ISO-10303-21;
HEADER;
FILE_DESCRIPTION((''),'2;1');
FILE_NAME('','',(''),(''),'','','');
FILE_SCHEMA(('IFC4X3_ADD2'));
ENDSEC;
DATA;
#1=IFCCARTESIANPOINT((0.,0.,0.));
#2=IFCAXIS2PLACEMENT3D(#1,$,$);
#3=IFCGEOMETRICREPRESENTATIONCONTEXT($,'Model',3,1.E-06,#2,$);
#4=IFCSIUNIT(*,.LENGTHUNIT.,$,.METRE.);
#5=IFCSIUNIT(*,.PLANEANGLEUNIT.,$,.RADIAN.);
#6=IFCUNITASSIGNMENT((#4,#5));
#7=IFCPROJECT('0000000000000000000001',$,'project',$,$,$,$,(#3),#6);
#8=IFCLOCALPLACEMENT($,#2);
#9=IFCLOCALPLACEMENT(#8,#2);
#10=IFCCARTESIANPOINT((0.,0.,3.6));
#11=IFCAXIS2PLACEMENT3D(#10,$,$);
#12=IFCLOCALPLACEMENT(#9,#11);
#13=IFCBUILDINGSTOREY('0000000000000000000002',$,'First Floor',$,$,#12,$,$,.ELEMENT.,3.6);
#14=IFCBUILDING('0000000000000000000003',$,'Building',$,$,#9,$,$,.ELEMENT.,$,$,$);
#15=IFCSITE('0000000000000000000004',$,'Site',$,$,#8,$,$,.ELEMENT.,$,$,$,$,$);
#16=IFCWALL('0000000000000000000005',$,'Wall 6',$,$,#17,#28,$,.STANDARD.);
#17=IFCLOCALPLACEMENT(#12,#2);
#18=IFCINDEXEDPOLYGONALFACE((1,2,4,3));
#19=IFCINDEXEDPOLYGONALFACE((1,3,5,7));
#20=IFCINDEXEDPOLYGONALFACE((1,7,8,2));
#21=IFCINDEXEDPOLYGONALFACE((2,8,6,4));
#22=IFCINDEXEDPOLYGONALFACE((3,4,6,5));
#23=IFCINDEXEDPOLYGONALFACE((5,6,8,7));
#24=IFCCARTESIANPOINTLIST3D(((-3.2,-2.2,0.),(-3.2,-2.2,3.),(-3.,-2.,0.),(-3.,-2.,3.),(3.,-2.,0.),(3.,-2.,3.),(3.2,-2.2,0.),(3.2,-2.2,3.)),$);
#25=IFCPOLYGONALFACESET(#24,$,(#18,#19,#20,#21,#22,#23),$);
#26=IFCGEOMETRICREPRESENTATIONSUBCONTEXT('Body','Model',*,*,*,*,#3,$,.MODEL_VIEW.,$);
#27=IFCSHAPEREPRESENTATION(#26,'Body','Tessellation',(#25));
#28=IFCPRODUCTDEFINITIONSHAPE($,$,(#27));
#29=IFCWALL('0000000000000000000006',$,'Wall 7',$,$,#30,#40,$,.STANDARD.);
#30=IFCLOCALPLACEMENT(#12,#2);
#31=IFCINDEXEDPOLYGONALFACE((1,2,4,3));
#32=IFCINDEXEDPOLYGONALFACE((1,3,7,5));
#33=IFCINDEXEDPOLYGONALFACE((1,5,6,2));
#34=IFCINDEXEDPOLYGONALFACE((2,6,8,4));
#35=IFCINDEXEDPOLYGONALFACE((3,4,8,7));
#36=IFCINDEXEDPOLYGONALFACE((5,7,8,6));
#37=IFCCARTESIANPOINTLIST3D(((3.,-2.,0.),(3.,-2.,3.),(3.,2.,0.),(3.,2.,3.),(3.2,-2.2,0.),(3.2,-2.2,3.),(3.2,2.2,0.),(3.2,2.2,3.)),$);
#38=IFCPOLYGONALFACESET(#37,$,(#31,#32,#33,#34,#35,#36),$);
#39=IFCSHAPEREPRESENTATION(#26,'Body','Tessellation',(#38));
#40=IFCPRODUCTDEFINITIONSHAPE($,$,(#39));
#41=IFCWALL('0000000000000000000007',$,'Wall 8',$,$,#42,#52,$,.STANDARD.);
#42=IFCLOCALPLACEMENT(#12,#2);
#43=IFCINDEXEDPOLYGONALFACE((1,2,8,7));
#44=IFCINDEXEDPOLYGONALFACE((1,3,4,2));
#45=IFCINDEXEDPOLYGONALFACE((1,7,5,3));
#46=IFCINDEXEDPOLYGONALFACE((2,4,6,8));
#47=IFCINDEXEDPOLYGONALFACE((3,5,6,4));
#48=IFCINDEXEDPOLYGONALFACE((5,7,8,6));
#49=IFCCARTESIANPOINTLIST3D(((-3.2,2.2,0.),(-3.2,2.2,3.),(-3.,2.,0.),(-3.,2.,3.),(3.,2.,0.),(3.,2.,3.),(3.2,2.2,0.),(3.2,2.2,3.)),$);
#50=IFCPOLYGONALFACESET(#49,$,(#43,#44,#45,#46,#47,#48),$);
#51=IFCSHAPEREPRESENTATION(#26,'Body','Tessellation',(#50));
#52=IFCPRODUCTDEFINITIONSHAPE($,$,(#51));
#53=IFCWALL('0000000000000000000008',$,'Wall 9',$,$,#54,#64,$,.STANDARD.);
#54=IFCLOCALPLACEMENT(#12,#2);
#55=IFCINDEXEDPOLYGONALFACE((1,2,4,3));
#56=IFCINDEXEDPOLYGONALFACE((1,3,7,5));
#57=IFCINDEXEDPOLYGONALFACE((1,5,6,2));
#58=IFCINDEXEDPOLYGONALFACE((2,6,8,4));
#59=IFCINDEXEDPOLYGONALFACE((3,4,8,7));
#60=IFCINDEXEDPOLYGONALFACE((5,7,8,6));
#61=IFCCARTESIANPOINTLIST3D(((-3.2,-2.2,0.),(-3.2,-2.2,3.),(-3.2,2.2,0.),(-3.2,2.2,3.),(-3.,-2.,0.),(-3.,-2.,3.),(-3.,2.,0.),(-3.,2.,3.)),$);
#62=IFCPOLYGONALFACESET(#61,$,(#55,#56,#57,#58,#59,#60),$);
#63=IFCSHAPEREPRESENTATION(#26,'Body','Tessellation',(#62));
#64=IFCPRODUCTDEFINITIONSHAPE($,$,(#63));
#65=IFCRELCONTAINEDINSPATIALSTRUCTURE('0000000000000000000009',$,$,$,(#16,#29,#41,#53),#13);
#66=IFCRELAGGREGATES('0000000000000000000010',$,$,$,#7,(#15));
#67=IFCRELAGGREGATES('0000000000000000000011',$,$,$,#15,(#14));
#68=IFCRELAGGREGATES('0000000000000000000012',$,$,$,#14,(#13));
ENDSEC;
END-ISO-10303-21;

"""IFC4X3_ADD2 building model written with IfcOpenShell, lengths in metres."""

from ifc_helpers import new_model, si_unit, frame, origin, place, context, subcontext, project, spatial, polyline, outline, extrude, element, save


model = new_model("IFC4X3_ADD2")

# Units and contexts
model_context = context("Model", 3, precision=1e-06, world=origin())
body_context = subcontext(model_context, "Body", "Model", "MODEL_VIEW")
ifc_project = project(units=[si_unit("LENGTHUNIT", "METRE"), si_unit("PLANEANGLEUNIT", "RADIAN")], contexts=[model_context])

# Site, building, storey
site_placement = place(None, origin())
site = spatial("IfcSite", under=ifc_project, at=site_placement, Name="Site", CompositionType="ELEMENT")
building_placement = place(site_placement, origin())
building = spatial("IfcBuilding", under=site, at=building_placement, Name="Building", CompositionType="ELEMENT")
storey_placement = place(building_placement, frame((0.0, 0.0, 3.6)))
storey = spatial("IfcBuildingStorey", under=building, at=storey_placement, Name="First Floor", CompositionType="ELEMENT", Elevation=3.6)

# Walls
wall_1_placement = place(storey_placement, origin())
element("IfcWall", 1, at=wall_1_placement, inside=storey, Name="Wall 6", PredefinedType="STANDARD", context=body_context, shape_type="SweptSolid", body=[
    extrude(outline(polyline([(-3.0, -2.0), (3.0, -2.0), (3.2, -2.2), (-3.2, -2.2), (-3.0, -2.0)])), origin(), (0.0, 0.0, 1.0), 3.0),
])
wall_2_placement = place(storey_placement, origin())
element("IfcWall", 2, at=wall_2_placement, inside=storey, Name="Wall 7", PredefinedType="STANDARD", context=body_context, shape_type="SweptSolid", body=[
    extrude(outline(polyline([(3.0, -2.0), (3.0, 2.0), (3.2, 2.2), (3.2, -2.2), (3.0, -2.0)])), origin(), (0.0, 0.0, 1.0), 3.0),
])
wall_3_placement = place(storey_placement, origin())
element("IfcWall", 3, at=wall_3_placement, inside=storey, Name="Wall 8", PredefinedType="STANDARD", context=body_context, shape_type="SweptSolid", body=[
    extrude(outline(polyline([(3.0, 2.0), (-3.0, 2.0), (-3.2, 2.2), (3.2, 2.2), (3.0, 2.0)])), origin(), (0.0, 0.0, 1.0), 3.0),
])
wall_4_placement = place(storey_placement, origin())
element("IfcWall", 4, at=wall_4_placement, inside=storey, Name="Wall 9", PredefinedType="STANDARD", context=body_context, shape_type="SweptSolid", body=[
    extrude(outline(polyline([(-3.0, 2.0), (-3.0, -2.0), (-3.2, -2.2), (-3.2, 2.2), (-3.0, 2.0)])), origin(), (0.0, 0.0, 1.0), 3.0),
])

save(model, "model.ifc")
